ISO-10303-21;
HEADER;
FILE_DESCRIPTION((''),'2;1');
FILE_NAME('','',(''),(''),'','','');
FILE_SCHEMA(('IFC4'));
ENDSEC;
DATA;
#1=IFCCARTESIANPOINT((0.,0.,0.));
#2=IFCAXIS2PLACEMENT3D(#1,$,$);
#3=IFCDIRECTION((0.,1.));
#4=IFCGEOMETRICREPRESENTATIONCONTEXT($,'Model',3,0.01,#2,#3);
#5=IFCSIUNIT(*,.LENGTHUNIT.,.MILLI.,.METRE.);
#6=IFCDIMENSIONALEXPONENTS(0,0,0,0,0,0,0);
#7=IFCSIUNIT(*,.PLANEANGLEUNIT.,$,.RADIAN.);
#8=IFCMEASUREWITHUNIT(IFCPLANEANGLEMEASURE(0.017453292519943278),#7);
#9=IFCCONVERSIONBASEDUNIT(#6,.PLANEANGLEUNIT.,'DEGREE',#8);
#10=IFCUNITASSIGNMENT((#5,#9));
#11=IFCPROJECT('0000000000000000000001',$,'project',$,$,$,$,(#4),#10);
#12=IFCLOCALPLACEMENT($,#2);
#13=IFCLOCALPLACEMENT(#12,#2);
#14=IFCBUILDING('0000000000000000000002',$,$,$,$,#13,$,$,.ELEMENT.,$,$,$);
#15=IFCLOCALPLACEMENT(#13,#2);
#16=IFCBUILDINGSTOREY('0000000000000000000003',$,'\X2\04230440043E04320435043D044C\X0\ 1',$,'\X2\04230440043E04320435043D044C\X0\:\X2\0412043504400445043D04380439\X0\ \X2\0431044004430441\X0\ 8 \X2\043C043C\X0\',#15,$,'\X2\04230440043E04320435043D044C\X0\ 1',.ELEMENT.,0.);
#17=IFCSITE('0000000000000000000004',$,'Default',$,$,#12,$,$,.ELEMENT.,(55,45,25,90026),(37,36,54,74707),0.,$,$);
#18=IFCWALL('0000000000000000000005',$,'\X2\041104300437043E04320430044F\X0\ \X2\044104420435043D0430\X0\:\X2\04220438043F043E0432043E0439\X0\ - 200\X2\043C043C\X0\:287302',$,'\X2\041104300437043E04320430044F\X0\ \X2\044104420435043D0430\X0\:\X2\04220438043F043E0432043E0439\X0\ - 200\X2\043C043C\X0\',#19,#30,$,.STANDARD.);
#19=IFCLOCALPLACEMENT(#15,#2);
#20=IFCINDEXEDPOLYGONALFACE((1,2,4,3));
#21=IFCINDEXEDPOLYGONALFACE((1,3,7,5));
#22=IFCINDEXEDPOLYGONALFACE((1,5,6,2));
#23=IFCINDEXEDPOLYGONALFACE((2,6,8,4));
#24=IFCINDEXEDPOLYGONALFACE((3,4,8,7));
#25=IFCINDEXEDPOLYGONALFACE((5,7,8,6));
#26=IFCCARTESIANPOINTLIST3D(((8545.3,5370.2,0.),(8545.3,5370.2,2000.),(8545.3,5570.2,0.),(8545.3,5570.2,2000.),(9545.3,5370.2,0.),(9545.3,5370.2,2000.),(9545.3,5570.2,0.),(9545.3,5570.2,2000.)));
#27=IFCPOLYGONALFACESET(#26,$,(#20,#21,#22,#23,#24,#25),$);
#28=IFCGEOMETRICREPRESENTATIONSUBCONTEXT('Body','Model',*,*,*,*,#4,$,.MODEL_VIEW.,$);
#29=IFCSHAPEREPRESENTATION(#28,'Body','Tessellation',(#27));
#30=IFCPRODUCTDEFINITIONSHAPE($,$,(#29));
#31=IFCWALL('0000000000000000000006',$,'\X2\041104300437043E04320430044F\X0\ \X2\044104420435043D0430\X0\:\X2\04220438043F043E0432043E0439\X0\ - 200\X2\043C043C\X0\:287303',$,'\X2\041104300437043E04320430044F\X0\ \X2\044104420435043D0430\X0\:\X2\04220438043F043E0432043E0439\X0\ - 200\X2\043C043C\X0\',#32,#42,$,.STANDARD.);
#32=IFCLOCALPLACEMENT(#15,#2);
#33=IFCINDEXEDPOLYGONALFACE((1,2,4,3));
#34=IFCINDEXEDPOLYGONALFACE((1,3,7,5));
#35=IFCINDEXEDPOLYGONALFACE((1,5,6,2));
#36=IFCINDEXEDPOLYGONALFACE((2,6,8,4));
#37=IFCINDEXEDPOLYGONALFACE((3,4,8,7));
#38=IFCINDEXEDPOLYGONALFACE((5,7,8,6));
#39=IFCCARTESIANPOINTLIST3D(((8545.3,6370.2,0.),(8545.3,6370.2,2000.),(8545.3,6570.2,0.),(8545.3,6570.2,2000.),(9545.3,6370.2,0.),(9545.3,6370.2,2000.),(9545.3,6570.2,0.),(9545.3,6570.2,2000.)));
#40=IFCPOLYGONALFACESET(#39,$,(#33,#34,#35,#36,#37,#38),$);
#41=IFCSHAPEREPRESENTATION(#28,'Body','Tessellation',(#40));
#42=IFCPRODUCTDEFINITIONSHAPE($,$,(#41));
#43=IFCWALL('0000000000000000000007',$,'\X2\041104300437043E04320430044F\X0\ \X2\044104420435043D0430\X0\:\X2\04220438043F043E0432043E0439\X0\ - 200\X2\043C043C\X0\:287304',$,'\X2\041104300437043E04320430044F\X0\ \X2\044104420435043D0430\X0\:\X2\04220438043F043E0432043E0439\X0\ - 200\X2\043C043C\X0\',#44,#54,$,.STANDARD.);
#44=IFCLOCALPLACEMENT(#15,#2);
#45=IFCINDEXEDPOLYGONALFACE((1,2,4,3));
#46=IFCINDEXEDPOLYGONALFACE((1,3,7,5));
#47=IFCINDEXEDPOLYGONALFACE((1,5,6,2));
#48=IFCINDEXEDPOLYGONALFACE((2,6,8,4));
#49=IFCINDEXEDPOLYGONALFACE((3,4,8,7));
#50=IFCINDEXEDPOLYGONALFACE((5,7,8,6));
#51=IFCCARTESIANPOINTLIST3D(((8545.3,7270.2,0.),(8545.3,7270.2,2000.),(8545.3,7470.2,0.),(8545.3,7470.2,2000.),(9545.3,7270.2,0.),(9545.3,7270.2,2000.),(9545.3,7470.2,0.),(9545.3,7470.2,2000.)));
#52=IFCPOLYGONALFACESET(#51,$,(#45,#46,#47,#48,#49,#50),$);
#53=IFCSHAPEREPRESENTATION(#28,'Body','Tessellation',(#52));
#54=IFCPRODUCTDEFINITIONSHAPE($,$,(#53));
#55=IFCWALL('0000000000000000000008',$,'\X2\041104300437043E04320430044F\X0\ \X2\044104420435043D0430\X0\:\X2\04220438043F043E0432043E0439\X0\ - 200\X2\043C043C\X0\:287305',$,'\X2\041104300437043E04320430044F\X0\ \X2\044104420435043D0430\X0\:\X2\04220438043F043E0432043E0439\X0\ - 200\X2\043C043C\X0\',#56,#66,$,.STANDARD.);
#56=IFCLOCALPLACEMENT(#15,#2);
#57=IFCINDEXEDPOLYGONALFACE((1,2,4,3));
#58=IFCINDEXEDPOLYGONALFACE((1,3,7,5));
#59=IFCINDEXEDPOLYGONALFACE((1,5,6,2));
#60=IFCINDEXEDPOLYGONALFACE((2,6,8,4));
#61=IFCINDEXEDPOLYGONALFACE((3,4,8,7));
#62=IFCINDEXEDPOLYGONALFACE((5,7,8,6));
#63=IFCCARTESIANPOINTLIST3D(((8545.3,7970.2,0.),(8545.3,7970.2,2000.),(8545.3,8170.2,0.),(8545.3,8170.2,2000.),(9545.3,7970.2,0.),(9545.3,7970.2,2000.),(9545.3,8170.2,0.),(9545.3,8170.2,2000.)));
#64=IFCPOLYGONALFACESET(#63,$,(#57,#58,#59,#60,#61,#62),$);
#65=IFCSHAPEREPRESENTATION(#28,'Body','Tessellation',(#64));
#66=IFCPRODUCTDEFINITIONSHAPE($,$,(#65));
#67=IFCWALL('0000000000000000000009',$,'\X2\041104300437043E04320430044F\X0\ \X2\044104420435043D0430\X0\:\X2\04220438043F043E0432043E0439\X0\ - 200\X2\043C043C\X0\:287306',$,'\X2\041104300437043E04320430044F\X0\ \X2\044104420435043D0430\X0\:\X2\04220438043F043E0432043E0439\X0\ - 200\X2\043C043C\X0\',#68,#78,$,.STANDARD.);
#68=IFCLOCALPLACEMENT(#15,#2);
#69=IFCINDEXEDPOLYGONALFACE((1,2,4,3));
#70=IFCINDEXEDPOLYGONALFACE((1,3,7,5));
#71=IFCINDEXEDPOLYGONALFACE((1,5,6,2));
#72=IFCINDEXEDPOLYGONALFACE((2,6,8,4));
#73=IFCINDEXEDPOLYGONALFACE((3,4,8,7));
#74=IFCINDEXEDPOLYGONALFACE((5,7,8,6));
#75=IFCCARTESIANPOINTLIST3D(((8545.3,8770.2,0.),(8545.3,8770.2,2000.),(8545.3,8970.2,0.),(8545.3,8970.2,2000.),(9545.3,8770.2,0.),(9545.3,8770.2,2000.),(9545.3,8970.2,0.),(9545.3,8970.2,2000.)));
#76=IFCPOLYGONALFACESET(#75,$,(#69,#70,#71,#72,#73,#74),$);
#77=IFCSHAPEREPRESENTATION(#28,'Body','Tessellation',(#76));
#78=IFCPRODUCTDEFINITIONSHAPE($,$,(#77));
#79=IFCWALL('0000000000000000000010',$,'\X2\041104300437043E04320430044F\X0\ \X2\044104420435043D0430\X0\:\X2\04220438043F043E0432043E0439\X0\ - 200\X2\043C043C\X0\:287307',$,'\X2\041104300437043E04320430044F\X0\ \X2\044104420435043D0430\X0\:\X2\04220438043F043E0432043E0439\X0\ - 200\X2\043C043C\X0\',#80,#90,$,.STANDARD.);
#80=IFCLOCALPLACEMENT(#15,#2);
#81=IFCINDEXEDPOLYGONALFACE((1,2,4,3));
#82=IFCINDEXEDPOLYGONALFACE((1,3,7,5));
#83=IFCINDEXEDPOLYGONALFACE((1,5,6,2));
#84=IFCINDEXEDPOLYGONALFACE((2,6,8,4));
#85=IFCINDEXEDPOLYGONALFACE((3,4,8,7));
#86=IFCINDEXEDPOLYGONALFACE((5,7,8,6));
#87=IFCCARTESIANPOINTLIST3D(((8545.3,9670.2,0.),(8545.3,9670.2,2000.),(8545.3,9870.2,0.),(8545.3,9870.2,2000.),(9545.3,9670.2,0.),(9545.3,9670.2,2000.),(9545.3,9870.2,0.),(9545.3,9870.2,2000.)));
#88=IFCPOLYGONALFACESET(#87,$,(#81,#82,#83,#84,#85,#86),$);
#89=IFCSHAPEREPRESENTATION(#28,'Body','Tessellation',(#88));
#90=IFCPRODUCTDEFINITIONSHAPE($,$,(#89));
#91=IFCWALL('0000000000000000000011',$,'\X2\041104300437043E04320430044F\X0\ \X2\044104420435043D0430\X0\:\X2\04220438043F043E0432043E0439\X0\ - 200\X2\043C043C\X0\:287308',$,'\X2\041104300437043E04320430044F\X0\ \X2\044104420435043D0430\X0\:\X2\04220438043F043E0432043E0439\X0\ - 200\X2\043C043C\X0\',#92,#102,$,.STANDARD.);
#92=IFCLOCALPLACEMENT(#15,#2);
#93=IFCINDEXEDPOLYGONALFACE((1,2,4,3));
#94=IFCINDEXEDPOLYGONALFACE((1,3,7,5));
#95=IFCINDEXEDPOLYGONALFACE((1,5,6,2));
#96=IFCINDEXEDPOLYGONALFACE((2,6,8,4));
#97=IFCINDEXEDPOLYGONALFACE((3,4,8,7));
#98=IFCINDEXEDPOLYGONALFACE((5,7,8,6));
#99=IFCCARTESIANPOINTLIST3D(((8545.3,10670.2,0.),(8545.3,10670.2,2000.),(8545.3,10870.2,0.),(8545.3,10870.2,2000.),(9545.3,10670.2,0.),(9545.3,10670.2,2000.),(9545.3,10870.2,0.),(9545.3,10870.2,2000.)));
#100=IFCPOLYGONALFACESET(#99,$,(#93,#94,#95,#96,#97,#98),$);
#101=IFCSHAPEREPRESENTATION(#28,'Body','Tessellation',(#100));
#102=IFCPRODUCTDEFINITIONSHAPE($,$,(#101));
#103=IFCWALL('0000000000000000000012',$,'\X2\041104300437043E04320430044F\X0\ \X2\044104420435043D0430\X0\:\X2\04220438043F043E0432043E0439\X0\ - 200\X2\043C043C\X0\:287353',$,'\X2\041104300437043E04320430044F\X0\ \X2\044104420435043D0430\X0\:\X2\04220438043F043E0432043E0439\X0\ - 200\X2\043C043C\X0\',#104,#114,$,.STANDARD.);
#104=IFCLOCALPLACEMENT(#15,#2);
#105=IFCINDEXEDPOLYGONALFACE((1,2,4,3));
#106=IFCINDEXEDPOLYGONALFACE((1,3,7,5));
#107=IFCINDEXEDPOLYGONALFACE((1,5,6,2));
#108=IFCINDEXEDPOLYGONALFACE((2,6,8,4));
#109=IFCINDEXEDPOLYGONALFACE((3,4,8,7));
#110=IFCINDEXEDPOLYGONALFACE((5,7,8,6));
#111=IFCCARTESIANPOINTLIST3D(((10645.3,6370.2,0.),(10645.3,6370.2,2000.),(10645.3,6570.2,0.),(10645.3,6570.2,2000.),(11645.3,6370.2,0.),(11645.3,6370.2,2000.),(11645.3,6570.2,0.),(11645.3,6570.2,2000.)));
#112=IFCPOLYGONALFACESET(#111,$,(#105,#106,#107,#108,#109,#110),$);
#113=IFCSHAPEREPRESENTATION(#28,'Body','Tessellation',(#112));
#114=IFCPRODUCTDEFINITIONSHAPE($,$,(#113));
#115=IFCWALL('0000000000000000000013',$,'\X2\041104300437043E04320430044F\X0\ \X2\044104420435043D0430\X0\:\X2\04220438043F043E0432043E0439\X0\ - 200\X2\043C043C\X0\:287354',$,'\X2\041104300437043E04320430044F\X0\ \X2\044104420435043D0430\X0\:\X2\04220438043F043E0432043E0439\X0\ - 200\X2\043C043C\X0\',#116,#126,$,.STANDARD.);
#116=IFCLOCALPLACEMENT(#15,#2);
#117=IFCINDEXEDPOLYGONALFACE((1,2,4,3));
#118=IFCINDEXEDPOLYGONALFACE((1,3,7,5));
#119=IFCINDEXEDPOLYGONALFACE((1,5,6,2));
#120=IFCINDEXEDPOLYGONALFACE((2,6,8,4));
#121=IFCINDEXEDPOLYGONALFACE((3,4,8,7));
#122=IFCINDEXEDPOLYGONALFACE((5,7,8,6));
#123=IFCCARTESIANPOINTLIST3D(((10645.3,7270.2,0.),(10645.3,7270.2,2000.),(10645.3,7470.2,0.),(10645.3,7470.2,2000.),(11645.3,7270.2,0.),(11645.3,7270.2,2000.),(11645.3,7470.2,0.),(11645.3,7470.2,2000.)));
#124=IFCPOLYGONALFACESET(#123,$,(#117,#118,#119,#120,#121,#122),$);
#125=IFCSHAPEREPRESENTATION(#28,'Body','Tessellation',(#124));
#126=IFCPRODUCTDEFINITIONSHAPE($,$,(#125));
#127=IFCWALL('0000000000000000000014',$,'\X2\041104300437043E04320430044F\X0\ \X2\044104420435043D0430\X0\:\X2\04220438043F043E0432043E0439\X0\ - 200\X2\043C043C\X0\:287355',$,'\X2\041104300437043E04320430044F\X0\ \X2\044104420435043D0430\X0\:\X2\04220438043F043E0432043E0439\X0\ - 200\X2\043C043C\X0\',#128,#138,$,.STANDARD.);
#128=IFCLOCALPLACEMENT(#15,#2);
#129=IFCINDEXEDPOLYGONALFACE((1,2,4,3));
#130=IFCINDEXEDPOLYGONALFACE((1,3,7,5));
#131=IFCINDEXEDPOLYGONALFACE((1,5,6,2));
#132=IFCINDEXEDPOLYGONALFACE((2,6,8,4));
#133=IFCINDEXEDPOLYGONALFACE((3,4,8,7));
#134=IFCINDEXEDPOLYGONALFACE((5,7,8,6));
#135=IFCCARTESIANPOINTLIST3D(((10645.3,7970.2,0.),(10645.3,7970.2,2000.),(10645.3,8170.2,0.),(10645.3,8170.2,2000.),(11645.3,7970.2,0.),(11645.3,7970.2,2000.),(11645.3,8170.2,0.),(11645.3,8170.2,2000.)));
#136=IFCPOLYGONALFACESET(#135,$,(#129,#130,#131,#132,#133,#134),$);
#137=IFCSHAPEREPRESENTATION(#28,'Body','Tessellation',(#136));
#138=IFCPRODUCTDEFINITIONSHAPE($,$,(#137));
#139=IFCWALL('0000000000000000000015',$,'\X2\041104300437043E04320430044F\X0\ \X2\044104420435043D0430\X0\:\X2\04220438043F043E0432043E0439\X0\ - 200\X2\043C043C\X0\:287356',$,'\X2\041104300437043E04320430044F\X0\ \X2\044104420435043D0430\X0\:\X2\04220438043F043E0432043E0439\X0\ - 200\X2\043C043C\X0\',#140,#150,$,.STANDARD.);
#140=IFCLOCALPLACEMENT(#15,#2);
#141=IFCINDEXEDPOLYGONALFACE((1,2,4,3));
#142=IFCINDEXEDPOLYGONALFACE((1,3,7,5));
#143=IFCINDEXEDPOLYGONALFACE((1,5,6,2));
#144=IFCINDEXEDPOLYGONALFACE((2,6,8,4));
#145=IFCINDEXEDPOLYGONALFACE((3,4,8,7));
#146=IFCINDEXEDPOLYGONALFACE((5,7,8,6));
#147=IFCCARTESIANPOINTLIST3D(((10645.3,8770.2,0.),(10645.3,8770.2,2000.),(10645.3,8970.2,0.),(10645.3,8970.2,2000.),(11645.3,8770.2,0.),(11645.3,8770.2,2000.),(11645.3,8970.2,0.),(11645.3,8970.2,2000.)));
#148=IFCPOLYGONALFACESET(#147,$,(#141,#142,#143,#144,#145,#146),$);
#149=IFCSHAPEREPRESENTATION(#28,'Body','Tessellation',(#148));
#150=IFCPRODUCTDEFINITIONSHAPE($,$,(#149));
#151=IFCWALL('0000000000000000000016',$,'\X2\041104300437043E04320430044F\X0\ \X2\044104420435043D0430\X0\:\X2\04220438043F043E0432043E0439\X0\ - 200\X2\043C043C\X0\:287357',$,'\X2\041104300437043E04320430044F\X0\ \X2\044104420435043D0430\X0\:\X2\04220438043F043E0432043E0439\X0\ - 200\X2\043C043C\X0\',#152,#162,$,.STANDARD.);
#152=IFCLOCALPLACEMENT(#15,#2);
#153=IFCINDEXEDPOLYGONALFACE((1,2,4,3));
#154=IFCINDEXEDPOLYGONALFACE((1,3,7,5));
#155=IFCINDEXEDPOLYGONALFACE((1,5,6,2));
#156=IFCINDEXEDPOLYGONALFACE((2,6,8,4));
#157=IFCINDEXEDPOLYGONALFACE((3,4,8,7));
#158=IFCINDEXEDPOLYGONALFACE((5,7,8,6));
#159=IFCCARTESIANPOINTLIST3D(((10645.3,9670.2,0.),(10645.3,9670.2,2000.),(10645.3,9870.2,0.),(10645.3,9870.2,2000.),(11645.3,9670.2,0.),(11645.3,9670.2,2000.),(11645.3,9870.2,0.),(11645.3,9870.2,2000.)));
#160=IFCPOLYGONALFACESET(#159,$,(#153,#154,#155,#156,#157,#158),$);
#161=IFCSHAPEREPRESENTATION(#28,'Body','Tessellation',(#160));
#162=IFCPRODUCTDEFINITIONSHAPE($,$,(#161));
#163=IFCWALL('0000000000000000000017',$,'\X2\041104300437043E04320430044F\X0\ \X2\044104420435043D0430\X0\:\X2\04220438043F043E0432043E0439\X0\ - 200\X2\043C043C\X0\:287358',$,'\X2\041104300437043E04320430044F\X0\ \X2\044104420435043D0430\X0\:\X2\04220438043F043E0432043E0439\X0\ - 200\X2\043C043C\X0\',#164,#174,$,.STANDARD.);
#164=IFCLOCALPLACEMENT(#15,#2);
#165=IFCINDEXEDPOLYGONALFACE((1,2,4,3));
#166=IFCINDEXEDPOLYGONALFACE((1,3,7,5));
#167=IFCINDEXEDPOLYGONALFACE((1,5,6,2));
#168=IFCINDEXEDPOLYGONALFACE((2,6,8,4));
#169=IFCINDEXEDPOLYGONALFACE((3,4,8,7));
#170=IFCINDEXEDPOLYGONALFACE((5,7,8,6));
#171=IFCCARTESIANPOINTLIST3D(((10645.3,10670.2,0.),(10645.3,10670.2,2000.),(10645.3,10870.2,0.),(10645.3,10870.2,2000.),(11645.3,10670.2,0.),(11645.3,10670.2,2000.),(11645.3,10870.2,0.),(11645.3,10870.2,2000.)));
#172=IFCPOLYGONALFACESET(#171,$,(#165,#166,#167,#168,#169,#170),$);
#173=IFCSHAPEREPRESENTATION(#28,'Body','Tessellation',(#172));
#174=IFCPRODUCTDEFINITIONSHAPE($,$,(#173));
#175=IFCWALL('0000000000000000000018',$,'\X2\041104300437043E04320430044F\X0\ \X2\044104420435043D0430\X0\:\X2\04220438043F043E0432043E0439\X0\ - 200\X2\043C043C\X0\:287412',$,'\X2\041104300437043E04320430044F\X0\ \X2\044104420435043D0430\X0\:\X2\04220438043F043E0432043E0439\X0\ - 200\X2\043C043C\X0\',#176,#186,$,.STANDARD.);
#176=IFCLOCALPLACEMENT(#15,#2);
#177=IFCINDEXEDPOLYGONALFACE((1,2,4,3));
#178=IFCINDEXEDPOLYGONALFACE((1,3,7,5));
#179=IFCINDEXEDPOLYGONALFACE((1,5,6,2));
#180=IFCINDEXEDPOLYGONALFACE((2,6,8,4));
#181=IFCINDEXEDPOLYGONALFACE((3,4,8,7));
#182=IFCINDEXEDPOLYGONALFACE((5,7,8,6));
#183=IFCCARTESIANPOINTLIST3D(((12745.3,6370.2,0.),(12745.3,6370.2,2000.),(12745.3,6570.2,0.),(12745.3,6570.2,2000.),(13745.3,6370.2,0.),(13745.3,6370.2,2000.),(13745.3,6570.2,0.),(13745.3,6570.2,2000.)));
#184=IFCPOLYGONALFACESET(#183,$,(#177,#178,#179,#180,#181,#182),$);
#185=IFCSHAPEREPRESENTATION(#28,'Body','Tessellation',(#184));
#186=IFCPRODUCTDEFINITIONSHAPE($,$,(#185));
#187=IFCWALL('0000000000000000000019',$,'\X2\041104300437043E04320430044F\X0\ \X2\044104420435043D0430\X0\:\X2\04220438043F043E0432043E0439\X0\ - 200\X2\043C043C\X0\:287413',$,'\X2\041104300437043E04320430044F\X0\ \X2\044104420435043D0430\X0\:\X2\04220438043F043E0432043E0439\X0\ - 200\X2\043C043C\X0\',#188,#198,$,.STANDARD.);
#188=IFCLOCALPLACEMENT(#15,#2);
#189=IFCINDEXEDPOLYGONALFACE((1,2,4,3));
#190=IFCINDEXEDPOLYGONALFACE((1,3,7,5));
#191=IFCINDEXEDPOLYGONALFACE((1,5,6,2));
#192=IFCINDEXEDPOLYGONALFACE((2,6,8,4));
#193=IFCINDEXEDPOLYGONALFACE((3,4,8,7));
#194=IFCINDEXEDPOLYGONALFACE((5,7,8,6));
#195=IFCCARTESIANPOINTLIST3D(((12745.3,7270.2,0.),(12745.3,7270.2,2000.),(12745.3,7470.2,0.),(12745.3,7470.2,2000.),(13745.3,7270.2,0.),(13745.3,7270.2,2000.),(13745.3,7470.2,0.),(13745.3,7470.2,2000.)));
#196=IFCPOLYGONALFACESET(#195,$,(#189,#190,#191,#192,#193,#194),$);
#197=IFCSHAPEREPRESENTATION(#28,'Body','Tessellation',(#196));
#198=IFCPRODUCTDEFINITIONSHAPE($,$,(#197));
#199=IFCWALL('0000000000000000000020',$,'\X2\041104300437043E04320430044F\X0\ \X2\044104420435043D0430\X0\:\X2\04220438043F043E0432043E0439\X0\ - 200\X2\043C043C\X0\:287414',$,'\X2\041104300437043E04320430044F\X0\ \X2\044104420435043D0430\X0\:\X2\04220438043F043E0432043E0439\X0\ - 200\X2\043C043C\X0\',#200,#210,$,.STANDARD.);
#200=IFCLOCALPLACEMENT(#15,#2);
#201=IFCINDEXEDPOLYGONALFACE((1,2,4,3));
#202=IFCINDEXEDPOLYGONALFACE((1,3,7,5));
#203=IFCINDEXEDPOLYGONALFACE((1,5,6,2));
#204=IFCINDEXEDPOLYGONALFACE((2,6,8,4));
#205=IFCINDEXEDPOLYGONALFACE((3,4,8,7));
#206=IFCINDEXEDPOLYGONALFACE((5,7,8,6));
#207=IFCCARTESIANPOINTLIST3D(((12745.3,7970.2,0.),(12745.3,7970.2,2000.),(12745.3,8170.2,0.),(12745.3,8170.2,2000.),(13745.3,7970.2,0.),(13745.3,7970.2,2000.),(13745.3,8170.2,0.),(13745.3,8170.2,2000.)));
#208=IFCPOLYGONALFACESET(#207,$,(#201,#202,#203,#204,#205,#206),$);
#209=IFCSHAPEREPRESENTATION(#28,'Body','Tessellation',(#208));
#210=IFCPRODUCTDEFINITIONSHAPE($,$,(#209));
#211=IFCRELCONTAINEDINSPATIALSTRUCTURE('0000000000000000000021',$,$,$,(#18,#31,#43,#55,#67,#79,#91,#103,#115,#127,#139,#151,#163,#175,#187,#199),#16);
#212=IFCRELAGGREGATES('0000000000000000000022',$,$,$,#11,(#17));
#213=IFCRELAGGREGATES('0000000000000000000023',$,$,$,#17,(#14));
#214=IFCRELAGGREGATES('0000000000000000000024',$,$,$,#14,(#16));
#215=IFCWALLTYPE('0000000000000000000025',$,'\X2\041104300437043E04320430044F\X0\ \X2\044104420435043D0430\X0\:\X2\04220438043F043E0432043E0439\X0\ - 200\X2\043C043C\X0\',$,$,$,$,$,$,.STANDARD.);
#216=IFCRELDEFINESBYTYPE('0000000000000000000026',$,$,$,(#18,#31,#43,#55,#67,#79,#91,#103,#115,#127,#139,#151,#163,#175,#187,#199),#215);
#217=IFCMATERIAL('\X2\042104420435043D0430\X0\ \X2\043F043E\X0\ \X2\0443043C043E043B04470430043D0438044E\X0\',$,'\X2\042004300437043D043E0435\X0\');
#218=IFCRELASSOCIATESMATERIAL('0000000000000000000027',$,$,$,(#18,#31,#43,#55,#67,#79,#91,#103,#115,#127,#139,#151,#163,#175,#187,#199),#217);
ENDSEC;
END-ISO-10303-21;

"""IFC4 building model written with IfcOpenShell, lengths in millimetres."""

from ifc_helpers import new_model, entity, si_unit, converted_unit, direction, frame, origin, place, context, subcontext, project, spatial, indexed_curve, outline, extrude, material, type_object, element, save


model = new_model("IFC4")

# Units and contexts
model_context = context("Model", 3, precision=0.01, world=origin(), true_north=direction((0.0, 1.0)))
body_context = subcontext(model_context, "Body", "Model", "MODEL_VIEW")
ifc_project = project(units=[si_unit("LENGTHUNIT", "METRE", prefix="MILLI"), converted_unit("PLANEANGLEUNIT", "DEGREE", entity("IfcPlaneAngleMeasure", 0.017453292519943278), si_unit("PLANEANGLEUNIT", "RADIAN"), dimensions=[0, 0, 0, 0, 0, 0, 0])], contexts=[model_context])

# Site, building, storey
site_placement = place(None, origin())
site = spatial("IfcSite", under=ifc_project, at=site_placement, Name="Default", CompositionType="ELEMENT", RefLatitude=(55, 45, 25, 90026), RefLongitude=(37, 36, 54, 74707), RefElevation=0.0)
building_placement = place(site_placement, origin())
building = spatial("IfcBuilding", under=site, at=building_placement, CompositionType="ELEMENT")
storey_placement = place(building_placement, origin())
storey = spatial("IfcBuildingStorey", under=building, at=storey_placement, Name="Уровень 1", ObjectType="Уровень:Верхний брус 8 мм", LongName="Уровень 1", CompositionType="ELEMENT", Elevation=0.0)

# Walls
ifc_material = material(Name="Стена по умолчанию", Category="Разное")
wall_type = type_object("IfcWallType", Name="Базовая стена:Типовой - 200мм", PredefinedType="STANDARD")
for number, where, name in (
    (1, (8545.3, 5470.2, 0.0), "Базовая стена:Типовой - 200мм:287302"),
    (2, (8545.3, 6470.2, 0.0), "Базовая стена:Типовой - 200мм:287303"),
):
    element("IfcWall", number, at=place(storey_placement, frame(where)), inside=storey, type_object=wall_type, material=ifc_material, Name=name, ObjectType="Базовая стена:Типовой - 200мм", PredefinedType="STANDARD", context=body_context, shape_type="SweptSolid", body=[
        extrude(outline(indexed_curve([(1000.0, 100.0), (0.0, 100.0), (0.0, -100.0), (1000.0, -100.0), (1000.0, 100.0)], self_intersect=False)), origin(), (0.0, 0.0, 1.0), 2000.0),
    ])
for number, where, name in (
    (3, (8545.3, 7370.2, 0.0), "Базовая стена:Типовой - 200мм:287304"),
    (4, (8545.3, 8070.2, 0.0), "Базовая стена:Типовой - 200мм:287305"),
):
    element("IfcWall", number, at=place(storey_placement, frame(where)), inside=storey, type_object=wall_type, material=ifc_material, Name=name, ObjectType="Базовая стена:Типовой - 200мм", PredefinedType="STANDARD", context=body_context, shape_type="SweptSolid", body=[
        extrude(outline(indexed_curve([(1000.0, 100.0), (0.0, 100.0), (0.0, -100.0), (1000.0, -100.0), (1000.0, 100.0)], self_intersect=False)), origin(), (0.0, 0.0, 1.0), 2000.0),
    ])
wall_1_placement = place(storey_placement, frame((8545.3, 8870.2, 0.0)))
element("IfcWall", 5, at=wall_1_placement, inside=storey, type_object=wall_type, material=ifc_material, Name="Базовая стена:Типовой - 200мм:287306", ObjectType="Базовая стена:Типовой - 200мм", PredefinedType="STANDARD", context=body_context, shape_type="SweptSolid", body=[
    extrude(outline(indexed_curve([(1000.0, 100.0), (0.0, 100.0), (0.0, -100.0), (1000.0, -100.0), (1000.0, 100.0)], self_intersect=False)), origin(), (0.0, 0.0, 1.0), 2000.0),
])
wall_2_placement = place(storey_placement, frame((8545.3, 9770.2, 0.0)))
element("IfcWall", 6, at=wall_2_placement, inside=storey, type_object=wall_type, material=ifc_material, Name="Базовая стена:Типовой - 200мм:287307", ObjectType="Базовая стена:Типовой - 200мм", PredefinedType="STANDARD", context=body_context, shape_type="SweptSolid", body=[
    extrude(outline(indexed_curve([(1000.0, 100.0), (0.0, 100.0), (0.0, -100.0), (1000.0, -100.0), (1000.0, 100.0)], self_intersect=False)), origin(), (0.0, 0.0, 1.0), 2000.0),
])
wall_3_placement = place(storey_placement, frame((8545.3, 10770.2, 0.0)))
element("IfcWall", 7, at=wall_3_placement, inside=storey, type_object=wall_type, material=ifc_material, Name="Базовая стена:Типовой - 200мм:287308", ObjectType="Базовая стена:Типовой - 200мм", PredefinedType="STANDARD", context=body_context, shape_type="SweptSolid", body=[
    extrude(outline(indexed_curve([(1000.0, 100.0), (0.0, 100.0), (0.0, -100.0), (1000.0, -100.0), (1000.0, 100.0)], self_intersect=False)), origin(), (0.0, 0.0, 1.0), 2000.0),
])
wall_4_placement = place(storey_placement, frame((10645.3, 6470.2, 0.0)))
element("IfcWall", 8, at=wall_4_placement, inside=storey, type_object=wall_type, material=ifc_material, Name="Базовая стена:Типовой - 200мм:287353", ObjectType="Базовая стена:Типовой - 200мм", PredefinedType="STANDARD", context=body_context, shape_type="SweptSolid", body=[
    extrude(outline(indexed_curve([(1000.0, 100.0), (0.0, 100.0), (0.0, -100.0), (1000.0, -100.0), (1000.0, 100.0)], self_intersect=False)), origin(), (0.0, 0.0, 1.0), 2000.0),
])
for number, where, name in (
    (9, (10645.3, 7370.2, 0.0), "Базовая стена:Типовой - 200мм:287354"),
    (10, (10645.3, 8070.2, 0.0), "Базовая стена:Типовой - 200мм:287355"),
):
    element("IfcWall", number, at=place(storey_placement, frame(where)), inside=storey, type_object=wall_type, material=ifc_material, Name=name, ObjectType="Базовая стена:Типовой - 200мм", PredefinedType="STANDARD", context=body_context, shape_type="SweptSolid", body=[
        extrude(outline(indexed_curve([(1000.0, 100.0), (0.0, 100.0), (0.0, -100.0), (1000.0, -100.0), (1000.0, 100.0)], self_intersect=False)), origin(), (0.0, 0.0, 1.0), 2000.0),
    ])
wall_5_placement = place(storey_placement, frame((10645.3, 8870.2, 0.0)))
element("IfcWall", 11, at=wall_5_placement, inside=storey, type_object=wall_type, material=ifc_material, Name="Базовая стена:Типовой - 200мм:287356", ObjectType="Базовая стена:Типовой - 200мм", PredefinedType="STANDARD", context=body_context, shape_type="SweptSolid", body=[
    extrude(outline(indexed_curve([(1000.0, 100.0), (0.0, 100.0), (0.0, -100.0), (1000.0, -100.0), (1000.0, 100.0)], self_intersect=False)), origin(), (0.0, 0.0, 1.0), 2000.0),
])
wall_6_placement = place(storey_placement, frame((10645.3, 9770.2, 0.0)))
element("IfcWall", 12, at=wall_6_placement, inside=storey, type_object=wall_type, material=ifc_material, Name="Базовая стена:Типовой - 200мм:287357", ObjectType="Базовая стена:Типовой - 200мм", PredefinedType="STANDARD", context=body_context, shape_type="SweptSolid", body=[
    extrude(outline(indexed_curve([(1000.0, 100.0), (0.0, 100.0), (0.0, -100.0), (1000.0, -100.0), (1000.0, 100.0)], self_intersect=False)), origin(), (0.0, 0.0, 1.0), 2000.0),
])
wall_7_placement = place(storey_placement, frame((10645.3, 10770.2, 0.0)))
element("IfcWall", 13, at=wall_7_placement, inside=storey, type_object=wall_type, material=ifc_material, Name="Базовая стена:Типовой - 200мм:287358", ObjectType="Базовая стена:Типовой - 200мм", PredefinedType="STANDARD", context=body_context, shape_type="SweptSolid", body=[
    extrude(outline(indexed_curve([(1000.0, 100.0), (0.0, 100.0), (0.0, -100.0), (1000.0, -100.0), (1000.0, 100.0)], self_intersect=False)), origin(), (0.0, 0.0, 1.0), 2000.0),
])
wall_8_placement = place(storey_placement, frame((12745.3, 6470.2, 0.0)))
element("IfcWall", 14, at=wall_8_placement, inside=storey, type_object=wall_type, material=ifc_material, Name="Базовая стена:Типовой - 200мм:287412", ObjectType="Базовая стена:Типовой - 200мм", PredefinedType="STANDARD", context=body_context, shape_type="SweptSolid", body=[
    extrude(outline(indexed_curve([(1000.0, 100.0), (0.0, 100.0), (0.0, -100.0), (1000.0, -100.0), (1000.0, 100.0)], self_intersect=False)), origin(), (0.0, 0.0, 1.0), 2000.0),
])
for number, where, name in (
    (15, (12745.3, 7370.2, 0.0), "Базовая стена:Типовой - 200мм:287413"),
    (16, (12745.3, 8070.2, 0.0), "Базовая стена:Типовой - 200мм:287414"),
):
    element("IfcWall", number, at=place(storey_placement, frame(where)), inside=storey, type_object=wall_type, material=ifc_material, Name=name, ObjectType="Базовая стена:Типовой - 200мм", PredefinedType="STANDARD", context=body_context, shape_type="SweptSolid", body=[
        extrude(outline(indexed_curve([(1000.0, 100.0), (0.0, 100.0), (0.0, -100.0), (1000.0, -100.0), (1000.0, 100.0)], self_intersect=False)), origin(), (0.0, 0.0, 1.0), 2000.0),
    ])

save(model, "model.ifc")
